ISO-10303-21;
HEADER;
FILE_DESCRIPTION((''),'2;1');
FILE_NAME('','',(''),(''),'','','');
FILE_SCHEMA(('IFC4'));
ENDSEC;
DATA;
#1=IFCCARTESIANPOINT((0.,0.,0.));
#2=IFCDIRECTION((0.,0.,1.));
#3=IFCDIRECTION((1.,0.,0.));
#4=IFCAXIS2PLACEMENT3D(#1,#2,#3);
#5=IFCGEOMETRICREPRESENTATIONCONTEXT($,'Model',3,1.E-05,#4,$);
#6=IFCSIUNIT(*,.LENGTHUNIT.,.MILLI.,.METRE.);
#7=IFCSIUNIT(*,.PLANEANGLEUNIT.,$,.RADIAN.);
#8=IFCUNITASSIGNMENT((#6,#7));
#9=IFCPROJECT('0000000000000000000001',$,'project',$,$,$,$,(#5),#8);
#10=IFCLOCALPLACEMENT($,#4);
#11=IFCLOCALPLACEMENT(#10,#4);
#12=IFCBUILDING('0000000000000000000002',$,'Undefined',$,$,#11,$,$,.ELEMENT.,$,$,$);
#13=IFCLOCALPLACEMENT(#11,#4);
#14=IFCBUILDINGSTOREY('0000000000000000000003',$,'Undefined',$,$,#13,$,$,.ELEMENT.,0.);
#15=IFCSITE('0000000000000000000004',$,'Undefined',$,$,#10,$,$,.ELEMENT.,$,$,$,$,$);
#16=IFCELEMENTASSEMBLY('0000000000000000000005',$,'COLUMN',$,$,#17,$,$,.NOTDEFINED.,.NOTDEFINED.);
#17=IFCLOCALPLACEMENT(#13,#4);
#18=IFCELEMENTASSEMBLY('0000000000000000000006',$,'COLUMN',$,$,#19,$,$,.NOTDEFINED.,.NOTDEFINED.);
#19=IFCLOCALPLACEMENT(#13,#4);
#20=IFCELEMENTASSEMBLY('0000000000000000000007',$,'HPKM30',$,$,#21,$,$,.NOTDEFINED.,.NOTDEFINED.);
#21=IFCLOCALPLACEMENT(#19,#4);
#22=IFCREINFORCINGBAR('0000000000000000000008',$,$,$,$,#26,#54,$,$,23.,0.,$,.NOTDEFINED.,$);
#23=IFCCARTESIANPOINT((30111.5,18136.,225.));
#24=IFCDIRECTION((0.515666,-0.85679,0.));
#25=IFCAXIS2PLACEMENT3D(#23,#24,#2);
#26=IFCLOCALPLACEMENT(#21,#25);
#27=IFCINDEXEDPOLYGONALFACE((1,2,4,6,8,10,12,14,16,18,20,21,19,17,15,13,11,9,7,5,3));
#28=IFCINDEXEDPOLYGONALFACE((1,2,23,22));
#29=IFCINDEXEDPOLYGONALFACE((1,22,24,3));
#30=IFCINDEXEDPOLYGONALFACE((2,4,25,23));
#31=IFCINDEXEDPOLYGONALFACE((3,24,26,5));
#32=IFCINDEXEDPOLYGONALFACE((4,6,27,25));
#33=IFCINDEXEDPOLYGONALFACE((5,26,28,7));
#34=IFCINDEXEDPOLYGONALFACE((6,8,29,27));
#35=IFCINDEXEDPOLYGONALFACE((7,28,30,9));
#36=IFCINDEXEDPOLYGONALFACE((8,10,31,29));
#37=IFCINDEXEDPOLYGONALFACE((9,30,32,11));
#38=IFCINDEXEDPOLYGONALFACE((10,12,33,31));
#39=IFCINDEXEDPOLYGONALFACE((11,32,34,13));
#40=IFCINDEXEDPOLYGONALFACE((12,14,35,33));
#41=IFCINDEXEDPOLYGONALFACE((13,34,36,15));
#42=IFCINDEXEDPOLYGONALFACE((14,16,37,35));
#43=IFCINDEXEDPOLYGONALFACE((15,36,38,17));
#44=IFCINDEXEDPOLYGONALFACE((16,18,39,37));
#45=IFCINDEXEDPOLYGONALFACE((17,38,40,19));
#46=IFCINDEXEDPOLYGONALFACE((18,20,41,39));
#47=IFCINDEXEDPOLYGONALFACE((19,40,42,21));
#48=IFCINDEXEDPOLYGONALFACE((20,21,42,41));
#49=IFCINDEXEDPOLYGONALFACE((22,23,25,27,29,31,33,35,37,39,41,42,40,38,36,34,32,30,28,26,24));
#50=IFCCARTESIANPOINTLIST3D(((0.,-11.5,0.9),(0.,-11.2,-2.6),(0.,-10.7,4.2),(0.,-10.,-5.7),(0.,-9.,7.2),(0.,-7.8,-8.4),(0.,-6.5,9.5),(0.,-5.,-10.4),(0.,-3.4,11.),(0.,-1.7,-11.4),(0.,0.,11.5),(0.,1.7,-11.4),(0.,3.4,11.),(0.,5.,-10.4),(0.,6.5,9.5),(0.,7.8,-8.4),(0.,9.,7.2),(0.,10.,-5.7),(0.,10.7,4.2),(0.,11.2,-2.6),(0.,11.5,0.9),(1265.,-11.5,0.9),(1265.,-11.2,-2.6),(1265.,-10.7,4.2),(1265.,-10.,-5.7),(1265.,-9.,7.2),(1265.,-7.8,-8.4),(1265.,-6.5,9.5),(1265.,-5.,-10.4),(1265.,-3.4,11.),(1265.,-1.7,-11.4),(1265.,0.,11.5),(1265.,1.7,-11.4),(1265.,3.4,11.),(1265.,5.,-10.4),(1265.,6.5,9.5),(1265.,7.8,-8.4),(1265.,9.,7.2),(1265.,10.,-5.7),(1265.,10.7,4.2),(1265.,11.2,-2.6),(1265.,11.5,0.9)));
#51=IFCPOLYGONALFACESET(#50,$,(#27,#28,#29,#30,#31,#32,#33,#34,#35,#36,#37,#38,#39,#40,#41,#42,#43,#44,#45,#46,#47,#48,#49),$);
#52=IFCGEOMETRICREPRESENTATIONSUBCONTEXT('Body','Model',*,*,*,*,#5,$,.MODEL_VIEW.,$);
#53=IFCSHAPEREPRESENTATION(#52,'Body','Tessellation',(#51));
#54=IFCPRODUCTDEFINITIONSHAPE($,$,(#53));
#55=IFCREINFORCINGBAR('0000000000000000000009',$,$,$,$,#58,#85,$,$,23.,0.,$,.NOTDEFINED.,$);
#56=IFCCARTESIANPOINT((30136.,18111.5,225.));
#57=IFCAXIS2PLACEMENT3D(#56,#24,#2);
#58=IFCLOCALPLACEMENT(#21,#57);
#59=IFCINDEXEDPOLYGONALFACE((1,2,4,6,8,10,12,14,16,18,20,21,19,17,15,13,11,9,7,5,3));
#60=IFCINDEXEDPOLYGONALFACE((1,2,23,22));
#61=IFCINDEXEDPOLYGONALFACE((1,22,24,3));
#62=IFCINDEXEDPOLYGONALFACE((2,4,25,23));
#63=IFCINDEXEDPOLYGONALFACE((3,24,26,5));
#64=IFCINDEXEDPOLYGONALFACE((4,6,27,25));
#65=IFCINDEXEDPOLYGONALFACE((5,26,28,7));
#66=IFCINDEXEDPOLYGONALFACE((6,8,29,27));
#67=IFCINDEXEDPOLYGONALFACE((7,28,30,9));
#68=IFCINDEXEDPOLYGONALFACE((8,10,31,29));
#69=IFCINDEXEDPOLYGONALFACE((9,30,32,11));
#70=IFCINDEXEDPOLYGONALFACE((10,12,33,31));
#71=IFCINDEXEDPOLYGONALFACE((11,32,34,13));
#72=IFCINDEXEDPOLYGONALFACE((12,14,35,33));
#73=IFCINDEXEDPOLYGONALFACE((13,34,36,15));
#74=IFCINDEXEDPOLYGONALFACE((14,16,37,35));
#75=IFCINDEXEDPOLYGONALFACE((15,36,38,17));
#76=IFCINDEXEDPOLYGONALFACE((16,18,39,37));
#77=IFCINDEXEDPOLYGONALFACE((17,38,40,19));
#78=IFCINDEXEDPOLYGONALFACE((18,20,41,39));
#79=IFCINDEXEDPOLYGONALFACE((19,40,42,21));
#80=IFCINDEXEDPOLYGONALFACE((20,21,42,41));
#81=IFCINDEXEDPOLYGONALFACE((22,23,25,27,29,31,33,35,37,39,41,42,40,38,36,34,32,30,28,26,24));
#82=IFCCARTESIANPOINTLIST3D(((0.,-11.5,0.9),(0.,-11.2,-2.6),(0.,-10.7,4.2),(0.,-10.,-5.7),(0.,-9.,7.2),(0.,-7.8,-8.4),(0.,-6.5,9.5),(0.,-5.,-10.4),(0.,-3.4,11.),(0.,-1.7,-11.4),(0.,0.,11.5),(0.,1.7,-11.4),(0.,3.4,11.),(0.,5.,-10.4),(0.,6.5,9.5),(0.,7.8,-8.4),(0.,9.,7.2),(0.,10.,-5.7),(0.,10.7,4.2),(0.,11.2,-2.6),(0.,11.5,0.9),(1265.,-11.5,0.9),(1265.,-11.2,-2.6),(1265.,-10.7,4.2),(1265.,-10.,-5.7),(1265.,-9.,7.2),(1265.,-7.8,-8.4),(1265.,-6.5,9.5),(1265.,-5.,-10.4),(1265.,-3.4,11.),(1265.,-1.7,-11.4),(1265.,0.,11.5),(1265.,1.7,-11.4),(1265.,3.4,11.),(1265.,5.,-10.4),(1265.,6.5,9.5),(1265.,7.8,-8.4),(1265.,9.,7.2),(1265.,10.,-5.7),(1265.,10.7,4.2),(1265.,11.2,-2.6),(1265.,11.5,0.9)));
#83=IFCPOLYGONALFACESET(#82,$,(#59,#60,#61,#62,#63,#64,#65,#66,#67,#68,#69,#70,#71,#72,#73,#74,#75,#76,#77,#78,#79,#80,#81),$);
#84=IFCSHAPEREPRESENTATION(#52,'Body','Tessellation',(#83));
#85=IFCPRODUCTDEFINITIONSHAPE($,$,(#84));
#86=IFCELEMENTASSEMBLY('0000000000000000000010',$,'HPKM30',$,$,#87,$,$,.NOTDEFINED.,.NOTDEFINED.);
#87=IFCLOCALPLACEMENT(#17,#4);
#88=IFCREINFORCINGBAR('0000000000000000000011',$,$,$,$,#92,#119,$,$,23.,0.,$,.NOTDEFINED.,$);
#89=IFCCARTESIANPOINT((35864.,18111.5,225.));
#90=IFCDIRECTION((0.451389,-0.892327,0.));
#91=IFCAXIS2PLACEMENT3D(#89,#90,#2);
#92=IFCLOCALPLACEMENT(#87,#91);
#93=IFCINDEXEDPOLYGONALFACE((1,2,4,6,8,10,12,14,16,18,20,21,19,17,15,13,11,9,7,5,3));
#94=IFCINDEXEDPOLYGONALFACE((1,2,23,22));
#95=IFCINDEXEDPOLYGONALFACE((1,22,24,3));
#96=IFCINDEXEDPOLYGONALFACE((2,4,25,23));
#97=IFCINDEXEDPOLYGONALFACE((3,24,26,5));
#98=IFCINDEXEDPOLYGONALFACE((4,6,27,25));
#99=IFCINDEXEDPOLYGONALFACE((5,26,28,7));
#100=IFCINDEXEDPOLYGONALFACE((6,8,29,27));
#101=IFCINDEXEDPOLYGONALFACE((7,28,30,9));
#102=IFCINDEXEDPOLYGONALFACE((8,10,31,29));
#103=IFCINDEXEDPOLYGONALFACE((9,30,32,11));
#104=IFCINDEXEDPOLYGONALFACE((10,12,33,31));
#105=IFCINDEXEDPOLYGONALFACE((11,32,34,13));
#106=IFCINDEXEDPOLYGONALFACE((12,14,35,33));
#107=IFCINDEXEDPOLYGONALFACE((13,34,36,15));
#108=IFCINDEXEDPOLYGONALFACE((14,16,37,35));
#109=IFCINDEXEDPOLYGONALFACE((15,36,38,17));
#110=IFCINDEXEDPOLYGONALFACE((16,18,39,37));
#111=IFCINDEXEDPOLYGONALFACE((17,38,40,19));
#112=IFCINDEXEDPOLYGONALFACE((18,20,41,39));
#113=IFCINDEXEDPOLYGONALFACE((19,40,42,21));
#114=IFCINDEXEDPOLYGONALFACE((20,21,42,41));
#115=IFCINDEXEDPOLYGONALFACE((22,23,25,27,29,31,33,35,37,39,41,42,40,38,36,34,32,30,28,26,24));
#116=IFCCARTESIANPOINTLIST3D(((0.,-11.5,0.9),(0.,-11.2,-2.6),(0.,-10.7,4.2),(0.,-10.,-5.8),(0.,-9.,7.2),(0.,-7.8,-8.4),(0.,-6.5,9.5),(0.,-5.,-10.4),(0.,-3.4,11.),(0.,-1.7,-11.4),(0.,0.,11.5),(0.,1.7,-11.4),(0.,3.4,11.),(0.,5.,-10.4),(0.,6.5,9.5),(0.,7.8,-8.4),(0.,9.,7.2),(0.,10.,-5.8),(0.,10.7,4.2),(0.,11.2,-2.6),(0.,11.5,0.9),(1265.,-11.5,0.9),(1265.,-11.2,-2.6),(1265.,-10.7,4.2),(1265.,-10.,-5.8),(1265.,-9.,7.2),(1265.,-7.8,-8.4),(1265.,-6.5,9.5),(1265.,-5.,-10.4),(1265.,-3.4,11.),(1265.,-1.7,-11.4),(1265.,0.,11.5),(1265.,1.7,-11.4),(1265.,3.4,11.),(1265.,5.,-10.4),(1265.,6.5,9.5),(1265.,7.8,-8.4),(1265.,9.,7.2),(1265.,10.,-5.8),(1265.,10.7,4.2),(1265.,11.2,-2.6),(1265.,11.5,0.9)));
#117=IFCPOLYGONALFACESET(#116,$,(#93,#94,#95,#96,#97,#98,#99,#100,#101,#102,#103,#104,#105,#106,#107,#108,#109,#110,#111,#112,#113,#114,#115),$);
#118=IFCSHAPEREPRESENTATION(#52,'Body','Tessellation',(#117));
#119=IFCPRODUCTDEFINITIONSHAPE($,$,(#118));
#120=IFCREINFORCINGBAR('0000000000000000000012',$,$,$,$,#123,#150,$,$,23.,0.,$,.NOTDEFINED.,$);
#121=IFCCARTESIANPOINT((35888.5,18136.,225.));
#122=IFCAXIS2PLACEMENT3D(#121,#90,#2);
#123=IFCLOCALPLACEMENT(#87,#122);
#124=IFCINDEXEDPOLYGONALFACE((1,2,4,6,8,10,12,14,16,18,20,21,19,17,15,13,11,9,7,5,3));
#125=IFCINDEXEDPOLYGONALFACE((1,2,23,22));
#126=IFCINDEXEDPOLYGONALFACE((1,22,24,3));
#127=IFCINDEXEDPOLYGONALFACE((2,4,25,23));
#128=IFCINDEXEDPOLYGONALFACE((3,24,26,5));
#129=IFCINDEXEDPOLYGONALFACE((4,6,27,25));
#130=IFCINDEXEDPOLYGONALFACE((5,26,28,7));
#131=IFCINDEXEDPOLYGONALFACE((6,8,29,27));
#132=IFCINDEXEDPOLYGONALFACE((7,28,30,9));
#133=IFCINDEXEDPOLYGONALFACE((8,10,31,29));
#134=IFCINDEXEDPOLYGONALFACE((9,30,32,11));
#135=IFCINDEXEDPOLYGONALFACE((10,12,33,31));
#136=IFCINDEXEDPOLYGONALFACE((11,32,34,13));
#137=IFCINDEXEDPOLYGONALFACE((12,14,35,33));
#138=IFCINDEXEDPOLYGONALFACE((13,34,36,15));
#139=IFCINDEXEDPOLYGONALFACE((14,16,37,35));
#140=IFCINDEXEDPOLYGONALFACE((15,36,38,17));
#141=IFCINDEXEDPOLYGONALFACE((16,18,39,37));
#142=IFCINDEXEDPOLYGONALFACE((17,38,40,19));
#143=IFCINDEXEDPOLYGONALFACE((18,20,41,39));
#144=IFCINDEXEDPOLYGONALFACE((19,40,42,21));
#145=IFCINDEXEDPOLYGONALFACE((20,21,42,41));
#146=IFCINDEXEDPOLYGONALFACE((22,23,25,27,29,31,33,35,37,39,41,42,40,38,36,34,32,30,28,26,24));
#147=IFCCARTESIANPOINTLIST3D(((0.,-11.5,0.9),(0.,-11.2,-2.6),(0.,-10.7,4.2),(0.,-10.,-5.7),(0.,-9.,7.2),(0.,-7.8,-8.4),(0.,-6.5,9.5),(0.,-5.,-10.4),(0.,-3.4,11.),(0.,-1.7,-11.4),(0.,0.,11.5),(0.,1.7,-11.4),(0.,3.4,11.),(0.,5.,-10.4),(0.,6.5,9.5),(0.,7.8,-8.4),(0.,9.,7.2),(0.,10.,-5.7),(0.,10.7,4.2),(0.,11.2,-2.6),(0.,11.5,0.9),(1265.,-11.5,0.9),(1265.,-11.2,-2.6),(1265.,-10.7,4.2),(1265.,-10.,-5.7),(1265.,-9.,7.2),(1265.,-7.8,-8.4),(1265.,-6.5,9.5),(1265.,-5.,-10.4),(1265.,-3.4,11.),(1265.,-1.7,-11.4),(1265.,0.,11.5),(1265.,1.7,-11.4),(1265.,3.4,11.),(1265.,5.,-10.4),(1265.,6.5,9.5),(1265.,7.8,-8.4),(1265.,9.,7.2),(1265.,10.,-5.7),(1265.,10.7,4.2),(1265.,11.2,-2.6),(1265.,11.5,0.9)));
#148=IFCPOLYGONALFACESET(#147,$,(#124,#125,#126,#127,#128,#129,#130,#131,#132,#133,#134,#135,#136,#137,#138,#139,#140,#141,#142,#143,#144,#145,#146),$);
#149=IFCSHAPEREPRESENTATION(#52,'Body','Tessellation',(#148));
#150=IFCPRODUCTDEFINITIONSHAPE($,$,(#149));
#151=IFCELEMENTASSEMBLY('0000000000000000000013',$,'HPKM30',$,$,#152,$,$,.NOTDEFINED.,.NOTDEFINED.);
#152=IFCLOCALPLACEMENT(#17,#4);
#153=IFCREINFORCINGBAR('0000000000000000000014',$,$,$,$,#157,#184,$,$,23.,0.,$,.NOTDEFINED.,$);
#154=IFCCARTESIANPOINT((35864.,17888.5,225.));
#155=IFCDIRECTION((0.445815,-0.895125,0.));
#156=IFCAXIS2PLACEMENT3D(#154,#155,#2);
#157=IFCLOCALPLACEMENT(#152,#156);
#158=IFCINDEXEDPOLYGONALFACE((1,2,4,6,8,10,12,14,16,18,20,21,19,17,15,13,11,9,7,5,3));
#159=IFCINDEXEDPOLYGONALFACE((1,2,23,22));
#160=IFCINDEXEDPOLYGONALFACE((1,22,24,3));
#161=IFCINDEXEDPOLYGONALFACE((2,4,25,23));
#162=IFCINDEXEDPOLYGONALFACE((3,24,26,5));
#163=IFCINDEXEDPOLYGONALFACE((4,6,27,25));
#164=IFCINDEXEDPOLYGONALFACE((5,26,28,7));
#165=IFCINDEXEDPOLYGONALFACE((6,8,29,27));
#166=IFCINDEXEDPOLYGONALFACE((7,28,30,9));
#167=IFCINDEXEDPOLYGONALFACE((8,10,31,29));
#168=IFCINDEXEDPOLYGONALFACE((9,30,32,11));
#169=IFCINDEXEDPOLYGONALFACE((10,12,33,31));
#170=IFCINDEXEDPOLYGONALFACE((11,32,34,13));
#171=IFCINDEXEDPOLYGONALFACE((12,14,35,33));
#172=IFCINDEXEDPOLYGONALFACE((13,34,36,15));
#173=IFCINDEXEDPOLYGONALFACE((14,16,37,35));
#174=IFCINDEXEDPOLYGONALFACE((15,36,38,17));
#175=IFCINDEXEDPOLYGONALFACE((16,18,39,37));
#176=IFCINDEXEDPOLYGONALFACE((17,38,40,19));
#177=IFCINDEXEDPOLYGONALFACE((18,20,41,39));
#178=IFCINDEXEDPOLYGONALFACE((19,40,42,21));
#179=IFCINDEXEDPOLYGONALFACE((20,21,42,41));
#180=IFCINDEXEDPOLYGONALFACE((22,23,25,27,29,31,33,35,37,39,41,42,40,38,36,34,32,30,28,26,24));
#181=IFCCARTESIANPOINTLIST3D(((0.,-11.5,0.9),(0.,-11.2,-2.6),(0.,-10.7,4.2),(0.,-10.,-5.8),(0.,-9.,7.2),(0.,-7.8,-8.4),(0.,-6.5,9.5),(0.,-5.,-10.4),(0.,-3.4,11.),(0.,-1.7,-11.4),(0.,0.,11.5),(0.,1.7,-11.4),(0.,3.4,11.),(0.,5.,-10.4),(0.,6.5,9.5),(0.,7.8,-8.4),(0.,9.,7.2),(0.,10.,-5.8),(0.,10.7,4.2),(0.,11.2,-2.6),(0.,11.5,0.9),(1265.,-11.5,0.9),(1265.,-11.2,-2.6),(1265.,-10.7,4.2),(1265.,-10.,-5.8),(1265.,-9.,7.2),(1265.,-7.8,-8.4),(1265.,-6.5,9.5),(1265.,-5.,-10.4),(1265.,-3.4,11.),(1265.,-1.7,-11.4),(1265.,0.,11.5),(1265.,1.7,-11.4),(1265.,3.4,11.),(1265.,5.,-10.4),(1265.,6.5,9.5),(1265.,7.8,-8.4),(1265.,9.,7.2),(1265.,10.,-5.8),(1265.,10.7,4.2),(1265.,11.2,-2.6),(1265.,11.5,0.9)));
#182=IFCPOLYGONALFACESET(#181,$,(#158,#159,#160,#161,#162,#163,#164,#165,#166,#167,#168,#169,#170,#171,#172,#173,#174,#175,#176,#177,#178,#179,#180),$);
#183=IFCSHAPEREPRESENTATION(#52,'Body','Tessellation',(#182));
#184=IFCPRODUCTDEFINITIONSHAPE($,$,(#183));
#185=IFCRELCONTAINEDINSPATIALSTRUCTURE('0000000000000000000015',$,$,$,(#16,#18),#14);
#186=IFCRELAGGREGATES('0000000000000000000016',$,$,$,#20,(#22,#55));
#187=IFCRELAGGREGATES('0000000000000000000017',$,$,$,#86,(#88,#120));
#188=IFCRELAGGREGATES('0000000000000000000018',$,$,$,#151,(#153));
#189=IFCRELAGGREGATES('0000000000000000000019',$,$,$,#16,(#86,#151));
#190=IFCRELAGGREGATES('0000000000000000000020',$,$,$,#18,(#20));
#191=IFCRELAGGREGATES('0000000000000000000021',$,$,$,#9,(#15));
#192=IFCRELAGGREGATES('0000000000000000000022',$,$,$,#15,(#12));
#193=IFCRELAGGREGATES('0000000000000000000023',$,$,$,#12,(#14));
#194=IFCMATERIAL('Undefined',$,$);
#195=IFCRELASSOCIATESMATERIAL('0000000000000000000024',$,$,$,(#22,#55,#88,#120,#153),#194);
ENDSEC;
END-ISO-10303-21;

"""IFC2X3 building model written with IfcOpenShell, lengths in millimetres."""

from ifc_helpers import new_model, entity, si_unit, frame, origin_with_axes, place, context, subcontext, project, spatial, source, transform, mapped, material, element, aggregate, save


model = new_model("IFC2X3")

# Units and contexts
model_context = context("Model", 3, precision=1e-05, world=origin_with_axes())
body_context = subcontext(model_context, "Body", "Model", "MODEL_VIEW")
ifc_project = project(units=[si_unit("LENGTHUNIT", "METRE", prefix="MILLI"), si_unit("PLANEANGLEUNIT", "RADIAN")], contexts=[model_context])

# Site, building, storey
site_placement = place(None, origin_with_axes())
site = spatial("IfcSite", under=ifc_project, at=site_placement, Name="Undefined", CompositionType="ELEMENT")
building_placement = place(site_placement, origin_with_axes())
building = spatial("IfcBuilding", under=site, at=building_placement, Name="Undefined", CompositionType="ELEMENT")
storey_placement = place(building_placement, origin_with_axes())
storey = spatial("IfcBuildingStorey", under=building, at=storey_placement, Name="Undefined", CompositionType="ELEMENT", Elevation=0.0)

# Element assembly
assembly_1_placement = place(storey_placement, origin_with_axes())
assembly_1 = element("IfcElementAssembly", 1, at=assembly_1_placement, inside=storey, Name="COLUMN", AssemblyPlace="NOTDEFINED", PredefinedType="NOTDEFINED")

# Shared definitions
ifc_material_1 = material(Name="Undefined")

# Element assembly
assembly_2_placement = place(storey_placement, origin_with_axes())
assembly_2 = element("IfcElementAssembly", 2, at=assembly_2_placement, inside=storey, Name="COLUMN", AssemblyPlace="NOTDEFINED", PredefinedType="NOTDEFINED")

# Element assemblies, reinforcing bars
assembly_3_placement = place(assembly_2_placement, origin_with_axes())
assembly_3 = element("IfcElementAssembly", 3, at=assembly_3_placement, Name="HPKM30", AssemblyPlace="NOTDEFINED", PredefinedType="NOTDEFINED")
shared_shape_1 = source(origin_with_axes(), body_context, "Body", "AdvancedSweptSolid", [
    entity("IfcSweptDiskSolid", entity("IfcTrimmedCurve", entity("IfcLine", entity("IfcCartesianPoint", [0.0, 0.0, 0.0]), entity("IfcVector", entity("IfcDirection", [1.0, 0.0, 0.0]), 1.0)), [entity("IfcParameterValue", 0.0)], [entity("IfcParameterValue", 1265.0)], True, "PARAMETER"), 11.5, None, 0.0, 1265.0),
])
reinforcing_bar_1_placement = place(assembly_3_placement, frame((30111.5, 18136.0, 225.0), z_axis=(0.515666, -0.85679, 0.0), x_axis=(0.0, 0.0, 1.0)))
reinforcing_bar_1 = element("IfcReinforcingBar", 4, at=reinforcing_bar_1_placement, material=ifc_material_1, BarRole="NOTDEFINED", CrossSectionArea=0.0, NominalDiameter=23.0, context=body_context, shape_type="MappedRepresentation", body=[
    mapped(shared_shape_1, transform((0.0, 0.0, 0.0))),
])
shared_shape_2 = source(origin_with_axes(), body_context, "Body", "AdvancedSweptSolid", [
    entity("IfcSweptDiskSolid", entity("IfcTrimmedCurve", entity("IfcLine", entity("IfcCartesianPoint", [0.0, 0.0, 0.0]), entity("IfcVector", entity("IfcDirection", [1.0, 0.0, 0.0]), 1.0)), [entity("IfcParameterValue", 0.0)], [entity("IfcParameterValue", 1265.0)], True, "PARAMETER"), 11.5, None, 0.0, 1265.0),
])
reinforcing_bar_2_placement = place(assembly_3_placement, frame((30136.0, 18111.5, 225.0), z_axis=(0.515666, -0.85679, 0.0), x_axis=(0.0, 0.0, 1.0)))
reinforcing_bar_2 = element("IfcReinforcingBar", 5, at=reinforcing_bar_2_placement, material=ifc_material_1, BarRole="NOTDEFINED", CrossSectionArea=0.0, NominalDiameter=23.0, context=body_context, shape_type="MappedRepresentation", body=[
    mapped(shared_shape_2, transform((0.0, 0.0, 0.0))),
])
aggregate(assembly_3, [reinforcing_bar_1, reinforcing_bar_2])
assembly_4_placement = place(assembly_1_placement, origin_with_axes())
assembly_4 = element("IfcElementAssembly", 6, at=assembly_4_placement, Name="HPKM30", AssemblyPlace="NOTDEFINED", PredefinedType="NOTDEFINED")
shared_shape_3 = source(origin_with_axes(), body_context, "Body", "AdvancedSweptSolid", [
    entity("IfcSweptDiskSolid", entity("IfcTrimmedCurve", entity("IfcLine", entity("IfcCartesianPoint", [0.0, 0.0, 0.0]), entity("IfcVector", entity("IfcDirection", [1.0, 0.0, 0.0]), 1.0)), [entity("IfcParameterValue", 0.0)], [entity("IfcParameterValue", 1265.0)], True, "PARAMETER"), 11.5, None, 0.0, 1265.0),
])
reinforcing_bar_3_placement = place(assembly_4_placement, frame((35864.0, 18111.5, 225.0), z_axis=(0.451389, -0.892327, 0.0), x_axis=(0.0, 0.0, 1.0)))
reinforcing_bar_3 = element("IfcReinforcingBar", 7, at=reinforcing_bar_3_placement, material=ifc_material_1, BarRole="NOTDEFINED", CrossSectionArea=0.0, NominalDiameter=23.0, context=body_context, shape_type="MappedRepresentation", body=[
    mapped(shared_shape_3, transform((0.0, 0.0, 0.0))),
])
shared_shape_4 = source(origin_with_axes(), body_context, "Body", "AdvancedSweptSolid", [
    entity("IfcSweptDiskSolid", entity("IfcTrimmedCurve", entity("IfcLine", entity("IfcCartesianPoint", [0.0, 0.0, 0.0]), entity("IfcVector", entity("IfcDirection", [1.0, 0.0, 0.0]), 1.0)), [entity("IfcParameterValue", 0.0)], [entity("IfcParameterValue", 1265.0)], True, "PARAMETER"), 11.5, None, 0.0, 1265.0),
])
reinforcing_bar_4_placement = place(assembly_4_placement, frame((35888.5, 18136.0, 225.0), z_axis=(0.451389, -0.892327, 0.0), x_axis=(0.0, 0.0, 1.0)))
reinforcing_bar_4 = element("IfcReinforcingBar", 8, at=reinforcing_bar_4_placement, material=ifc_material_1, BarRole="NOTDEFINED", CrossSectionArea=0.0, NominalDiameter=23.0, context=body_context, shape_type="MappedRepresentation", body=[
    mapped(shared_shape_4, transform((0.0, 0.0, 0.0))),
])
aggregate(assembly_4, [reinforcing_bar_3, reinforcing_bar_4])

# Element assembly, reinforcing bar
assembly_5_placement = place(assembly_1_placement, origin_with_axes())
assembly_5 = element("IfcElementAssembly", 9, at=assembly_5_placement, Name="HPKM30", AssemblyPlace="NOTDEFINED", PredefinedType="NOTDEFINED")
shared_shape_5 = source(origin_with_axes(), body_context, "Body", "AdvancedSweptSolid", [
    entity("IfcSweptDiskSolid", entity("IfcTrimmedCurve", entity("IfcLine", entity("IfcCartesianPoint", [0.0, 0.0, 0.0]), entity("IfcVector", entity("IfcDirection", [1.0, 0.0, 0.0]), 1.0)), [entity("IfcParameterValue", 0.0)], [entity("IfcParameterValue", 1265.0)], True, "PARAMETER"), 11.5, None, 0.0, 1265.0),
])
reinforcing_bar_5_placement = place(assembly_5_placement, frame((35864.0, 17888.5, 225.0), z_axis=(0.445815, -0.895125, 0.0), x_axis=(0.0, 0.0, 1.0)))
reinforcing_bar_5 = element("IfcReinforcingBar", 10, at=reinforcing_bar_5_placement, material=ifc_material_1, BarRole="NOTDEFINED", CrossSectionArea=0.0, NominalDiameter=23.0, context=body_context, shape_type="MappedRepresentation", body=[
    mapped(shared_shape_5, transform((0.0, 0.0, 0.0))),
])
aggregate(assembly_5, [reinforcing_bar_5])

aggregate(assembly_1, [assembly_4, assembly_5])
aggregate(assembly_2, [assembly_3])

save(model, "model.ifc")
